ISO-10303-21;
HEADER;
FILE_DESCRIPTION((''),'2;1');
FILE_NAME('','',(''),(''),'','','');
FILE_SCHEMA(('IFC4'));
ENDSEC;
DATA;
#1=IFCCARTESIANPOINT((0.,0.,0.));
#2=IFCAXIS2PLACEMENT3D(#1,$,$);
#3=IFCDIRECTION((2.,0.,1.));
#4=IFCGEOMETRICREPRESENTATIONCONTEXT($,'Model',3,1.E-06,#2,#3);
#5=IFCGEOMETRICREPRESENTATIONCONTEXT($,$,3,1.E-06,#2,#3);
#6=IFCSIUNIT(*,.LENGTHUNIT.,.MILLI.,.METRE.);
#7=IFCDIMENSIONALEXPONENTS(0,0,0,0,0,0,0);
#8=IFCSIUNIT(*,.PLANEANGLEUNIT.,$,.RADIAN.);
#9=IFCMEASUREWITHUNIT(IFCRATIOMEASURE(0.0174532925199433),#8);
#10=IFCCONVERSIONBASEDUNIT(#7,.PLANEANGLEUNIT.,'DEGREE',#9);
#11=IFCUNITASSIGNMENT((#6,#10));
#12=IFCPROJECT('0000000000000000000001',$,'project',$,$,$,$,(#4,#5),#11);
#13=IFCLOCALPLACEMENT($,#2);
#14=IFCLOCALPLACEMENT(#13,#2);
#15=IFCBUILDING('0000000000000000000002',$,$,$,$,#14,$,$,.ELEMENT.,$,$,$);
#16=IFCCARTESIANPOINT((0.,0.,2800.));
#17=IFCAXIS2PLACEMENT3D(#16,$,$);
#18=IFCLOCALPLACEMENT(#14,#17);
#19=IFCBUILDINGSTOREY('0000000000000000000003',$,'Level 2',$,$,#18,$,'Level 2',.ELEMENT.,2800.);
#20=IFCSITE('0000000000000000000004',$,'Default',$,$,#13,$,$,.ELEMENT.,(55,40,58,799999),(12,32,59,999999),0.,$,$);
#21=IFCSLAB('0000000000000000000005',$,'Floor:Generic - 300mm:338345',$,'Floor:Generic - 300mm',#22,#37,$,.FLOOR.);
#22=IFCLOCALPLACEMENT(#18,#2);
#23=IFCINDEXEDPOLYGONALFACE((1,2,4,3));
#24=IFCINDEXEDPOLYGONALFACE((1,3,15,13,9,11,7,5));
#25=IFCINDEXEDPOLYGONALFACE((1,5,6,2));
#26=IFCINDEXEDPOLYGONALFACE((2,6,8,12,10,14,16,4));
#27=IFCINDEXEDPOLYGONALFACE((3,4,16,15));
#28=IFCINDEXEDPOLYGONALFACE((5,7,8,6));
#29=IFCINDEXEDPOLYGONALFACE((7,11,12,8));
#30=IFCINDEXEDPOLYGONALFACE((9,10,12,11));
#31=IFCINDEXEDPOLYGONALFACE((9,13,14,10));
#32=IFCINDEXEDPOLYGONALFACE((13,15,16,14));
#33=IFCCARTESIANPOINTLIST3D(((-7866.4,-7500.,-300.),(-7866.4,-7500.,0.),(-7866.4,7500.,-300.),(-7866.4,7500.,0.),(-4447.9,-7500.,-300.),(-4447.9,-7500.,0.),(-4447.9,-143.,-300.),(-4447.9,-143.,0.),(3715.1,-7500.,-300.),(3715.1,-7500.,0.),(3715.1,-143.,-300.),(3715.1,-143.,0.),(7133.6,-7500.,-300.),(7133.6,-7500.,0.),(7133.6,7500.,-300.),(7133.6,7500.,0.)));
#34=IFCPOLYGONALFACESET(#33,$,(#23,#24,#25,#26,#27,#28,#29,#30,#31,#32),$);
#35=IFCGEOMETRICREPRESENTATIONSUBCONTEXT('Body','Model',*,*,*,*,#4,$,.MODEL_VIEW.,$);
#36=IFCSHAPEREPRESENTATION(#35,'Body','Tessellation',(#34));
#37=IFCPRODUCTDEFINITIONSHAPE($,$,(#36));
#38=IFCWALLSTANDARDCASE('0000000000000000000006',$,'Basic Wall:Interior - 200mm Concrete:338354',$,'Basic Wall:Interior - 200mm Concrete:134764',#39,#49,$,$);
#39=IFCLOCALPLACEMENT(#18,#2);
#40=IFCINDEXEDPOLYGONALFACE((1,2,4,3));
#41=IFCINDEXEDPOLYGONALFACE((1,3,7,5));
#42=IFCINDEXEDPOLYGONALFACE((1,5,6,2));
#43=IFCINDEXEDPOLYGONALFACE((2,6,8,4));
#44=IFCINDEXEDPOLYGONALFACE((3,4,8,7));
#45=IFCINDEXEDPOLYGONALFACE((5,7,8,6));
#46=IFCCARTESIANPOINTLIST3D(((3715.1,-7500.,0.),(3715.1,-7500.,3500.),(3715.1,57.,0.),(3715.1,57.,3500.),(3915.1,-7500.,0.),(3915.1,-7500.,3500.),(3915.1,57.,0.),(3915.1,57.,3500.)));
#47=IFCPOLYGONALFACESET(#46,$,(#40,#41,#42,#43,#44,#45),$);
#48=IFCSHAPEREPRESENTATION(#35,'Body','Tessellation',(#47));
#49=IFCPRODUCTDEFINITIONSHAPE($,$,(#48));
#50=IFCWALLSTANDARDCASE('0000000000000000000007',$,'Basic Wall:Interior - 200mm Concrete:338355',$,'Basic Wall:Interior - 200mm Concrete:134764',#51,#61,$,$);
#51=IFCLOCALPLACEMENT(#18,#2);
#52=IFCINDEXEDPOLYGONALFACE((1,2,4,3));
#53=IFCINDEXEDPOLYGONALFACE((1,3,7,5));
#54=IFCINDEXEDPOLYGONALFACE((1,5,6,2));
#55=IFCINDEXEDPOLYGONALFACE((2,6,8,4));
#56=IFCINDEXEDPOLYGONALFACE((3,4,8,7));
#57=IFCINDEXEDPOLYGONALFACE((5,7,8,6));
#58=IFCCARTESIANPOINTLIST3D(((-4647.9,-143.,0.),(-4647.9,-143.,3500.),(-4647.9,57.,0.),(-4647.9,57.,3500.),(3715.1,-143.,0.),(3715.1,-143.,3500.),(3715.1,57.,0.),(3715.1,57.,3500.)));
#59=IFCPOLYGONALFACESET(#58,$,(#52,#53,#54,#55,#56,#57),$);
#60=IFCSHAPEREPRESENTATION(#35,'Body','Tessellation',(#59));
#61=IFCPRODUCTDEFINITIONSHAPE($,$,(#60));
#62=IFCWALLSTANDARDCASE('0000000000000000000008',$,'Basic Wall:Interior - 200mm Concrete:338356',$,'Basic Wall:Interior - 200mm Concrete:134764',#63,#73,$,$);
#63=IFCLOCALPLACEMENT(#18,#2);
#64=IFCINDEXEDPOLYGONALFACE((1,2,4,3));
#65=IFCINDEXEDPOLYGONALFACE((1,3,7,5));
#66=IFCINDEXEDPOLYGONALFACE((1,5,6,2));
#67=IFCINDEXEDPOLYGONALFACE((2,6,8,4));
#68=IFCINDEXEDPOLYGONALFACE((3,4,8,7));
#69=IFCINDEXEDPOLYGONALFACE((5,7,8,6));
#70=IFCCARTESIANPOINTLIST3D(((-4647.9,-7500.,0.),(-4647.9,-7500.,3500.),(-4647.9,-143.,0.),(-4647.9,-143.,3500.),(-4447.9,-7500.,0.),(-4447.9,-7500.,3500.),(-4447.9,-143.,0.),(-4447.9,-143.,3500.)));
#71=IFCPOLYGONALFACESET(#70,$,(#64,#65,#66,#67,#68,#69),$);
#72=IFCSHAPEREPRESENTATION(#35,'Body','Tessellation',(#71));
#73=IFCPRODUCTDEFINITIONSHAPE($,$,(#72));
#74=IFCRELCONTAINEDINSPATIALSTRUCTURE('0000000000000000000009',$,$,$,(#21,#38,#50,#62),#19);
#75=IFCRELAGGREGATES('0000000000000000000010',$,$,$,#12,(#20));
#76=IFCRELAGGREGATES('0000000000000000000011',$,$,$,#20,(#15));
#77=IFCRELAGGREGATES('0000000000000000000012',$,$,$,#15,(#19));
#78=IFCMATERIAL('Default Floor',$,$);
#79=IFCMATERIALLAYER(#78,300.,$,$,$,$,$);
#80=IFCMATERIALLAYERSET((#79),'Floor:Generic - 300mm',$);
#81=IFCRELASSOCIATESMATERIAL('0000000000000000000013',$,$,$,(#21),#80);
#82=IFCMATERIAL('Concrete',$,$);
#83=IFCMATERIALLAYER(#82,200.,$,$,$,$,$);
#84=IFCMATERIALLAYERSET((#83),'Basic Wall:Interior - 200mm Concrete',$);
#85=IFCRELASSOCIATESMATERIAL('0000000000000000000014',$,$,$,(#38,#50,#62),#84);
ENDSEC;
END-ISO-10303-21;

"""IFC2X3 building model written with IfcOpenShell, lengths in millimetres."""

from ifc_helpers import new_model, entity, si_unit, converted_unit, direction, frame, frame_2d, origin, place, context, subcontext, project, spatial, polyline, rectangle, outline, extrude, material, layer, layer_set, layer_usage, element, save


model = new_model("IFC2X3")

# Units and contexts
model_context = context("Model", 3, precision=1e-06, world=origin(), true_north=direction((2.0, 0.0, 1.0)))
context_of_model = context(None, 3, precision=1e-06, world=origin(), true_north=direction((2.0, 0.0, 1.0)))
body_context = subcontext(model_context, "Body", "Model", "MODEL_VIEW")
ifc_project = project(units=[si_unit("LENGTHUNIT", "METRE", prefix="MILLI"), converted_unit("PLANEANGLEUNIT", "DEGREE", entity("IfcRatioMeasure", 0.0174532925199433), si_unit("PLANEANGLEUNIT", "RADIAN"), dimensions=[0, 0, 0, 0, 0, 0, 0])], contexts=[model_context, context_of_model])

# Site, building, storey
site_placement = place(None, origin())
site = spatial("IfcSite", under=ifc_project, at=site_placement, Name="Default", CompositionType="ELEMENT", RefLatitude=(55, 40, 58, 799999), RefLongitude=(12, 32, 59, 999999), RefElevation=0.0)
building_placement = place(site_placement, origin())
building = spatial("IfcBuilding", under=site, at=building_placement, CompositionType="ELEMENT")
storey_placement = place(building_placement, frame((0.0, 0.0, 2800.0)))
storey = spatial("IfcBuildingStorey", under=building, at=storey_placement, Name="Level 2", LongName="Level 2", CompositionType="ELEMENT", Elevation=2800.0)

# Slab
ifc_material_1 = material(Name="Default Floor")
ifc_layer_1 = layer(ifc_material_1, 300.0)
ifc_layer_set_1 = layer_set([ifc_layer_1], Name="Floor:Generic - 300mm")
ifc_layer_usage_1 = layer_usage(ifc_layer_set_1, "AXIS3", "POSITIVE", 0.0)
slab_placement = place(storey_placement, frame((-7866.4, -7500.0, -300.0)))
element("IfcSlab", 1, at=slab_placement, inside=storey, material=ifc_layer_usage_1, Name="Floor:Generic - 300mm:338345", ObjectType="Floor:Generic - 300mm", PredefinedType="FLOOR", context=body_context, shape_type="SweptSolid", body=[
    extrude(outline(polyline([(-7500.0, -7500.0), (-4081.5, -7500.0), (-4081.5, -143.0), (4081.5, -143.0), (4081.5, -7500.0), (7500.0, -7500.0), (7500.0, 7500.0), (-7500.0, 7500.0), (-7500.0, -7500.0)])), frame((7500.0, 7500.0, 300.0), z_axis=(0.0, 0.0, -1.0), x_axis=(-1.0, 0.0, 0.0)), (0.0, 0.0, 1.0), 300.0),
])

# Walls
ifc_material_2 = material(Name="Concrete")
ifc_layer_2 = layer(ifc_material_2, 200.0)
ifc_layer_set_2 = layer_set([ifc_layer_2], Name="Basic Wall:Interior - 200mm Concrete")
ifc_layer_usage_2 = layer_usage(ifc_layer_set_2, "AXIS2", "NEGATIVE", 100.0)
wall_1_placement = place(storey_placement, frame((3815.1, -7500.0, 0.0), z_axis=(0.0, 0.0, 1.0), x_axis=(0.0, 1.0, 0.0)))
element("IfcWallStandardCase", 2, at=wall_1_placement, inside=storey, material=ifc_layer_usage_2, Name="Basic Wall:Interior - 200mm Concrete:338354", ObjectType="Basic Wall:Interior - 200mm Concrete:134764", context=body_context, shape_type="SweptSolid", body=[
    extrude(rectangle(XDim=7557.0, YDim=200.0, at=frame_2d((3778.5, 0.0), x_axis=(-1.0, 0.0))), origin(), (0.0, 0.0, 1.0), 3500.0),
])
ifc_layer_usage_3 = layer_usage(ifc_layer_set_2, "AXIS2", "NEGATIVE", 100.0)
wall_2_placement = place(storey_placement, frame((3715.1, -43.0, 0.0), z_axis=(0.0, 0.0, 1.0), x_axis=(-1.0, 0.0, 0.0)))
element("IfcWallStandardCase", 3, at=wall_2_placement, inside=storey, material=ifc_layer_usage_3, Name="Basic Wall:Interior - 200mm Concrete:338355", ObjectType="Basic Wall:Interior - 200mm Concrete:134764", context=body_context, shape_type="SweptSolid", body=[
    extrude(rectangle(XDim=8363.0, YDim=200.0, at=frame_2d((4181.5, 0.0), x_axis=(-1.0, 0.0))), origin(), (0.0, 0.0, 1.0), 3500.0),
])
ifc_layer_usage_4 = layer_usage(ifc_layer_set_2, "AXIS2", "NEGATIVE", 100.0)
wall_3_placement = place(storey_placement, frame((-4547.9, -143.0, 0.0), z_axis=(0.0, 0.0, 1.0), x_axis=(0.0, -1.0, 0.0)))
element("IfcWallStandardCase", 4, at=wall_3_placement, inside=storey, material=ifc_layer_usage_4, Name="Basic Wall:Interior - 200mm Concrete:338356", ObjectType="Basic Wall:Interior - 200mm Concrete:134764", context=body_context, shape_type="SweptSolid", body=[
    extrude(rectangle(XDim=7357.0, YDim=200.0, at=frame_2d((3678.5, 0.0), x_axis=(-1.0, 0.0))), origin(), (0.0, 0.0, 1.0), 3500.0),
])

save(model, "model.ifc")
